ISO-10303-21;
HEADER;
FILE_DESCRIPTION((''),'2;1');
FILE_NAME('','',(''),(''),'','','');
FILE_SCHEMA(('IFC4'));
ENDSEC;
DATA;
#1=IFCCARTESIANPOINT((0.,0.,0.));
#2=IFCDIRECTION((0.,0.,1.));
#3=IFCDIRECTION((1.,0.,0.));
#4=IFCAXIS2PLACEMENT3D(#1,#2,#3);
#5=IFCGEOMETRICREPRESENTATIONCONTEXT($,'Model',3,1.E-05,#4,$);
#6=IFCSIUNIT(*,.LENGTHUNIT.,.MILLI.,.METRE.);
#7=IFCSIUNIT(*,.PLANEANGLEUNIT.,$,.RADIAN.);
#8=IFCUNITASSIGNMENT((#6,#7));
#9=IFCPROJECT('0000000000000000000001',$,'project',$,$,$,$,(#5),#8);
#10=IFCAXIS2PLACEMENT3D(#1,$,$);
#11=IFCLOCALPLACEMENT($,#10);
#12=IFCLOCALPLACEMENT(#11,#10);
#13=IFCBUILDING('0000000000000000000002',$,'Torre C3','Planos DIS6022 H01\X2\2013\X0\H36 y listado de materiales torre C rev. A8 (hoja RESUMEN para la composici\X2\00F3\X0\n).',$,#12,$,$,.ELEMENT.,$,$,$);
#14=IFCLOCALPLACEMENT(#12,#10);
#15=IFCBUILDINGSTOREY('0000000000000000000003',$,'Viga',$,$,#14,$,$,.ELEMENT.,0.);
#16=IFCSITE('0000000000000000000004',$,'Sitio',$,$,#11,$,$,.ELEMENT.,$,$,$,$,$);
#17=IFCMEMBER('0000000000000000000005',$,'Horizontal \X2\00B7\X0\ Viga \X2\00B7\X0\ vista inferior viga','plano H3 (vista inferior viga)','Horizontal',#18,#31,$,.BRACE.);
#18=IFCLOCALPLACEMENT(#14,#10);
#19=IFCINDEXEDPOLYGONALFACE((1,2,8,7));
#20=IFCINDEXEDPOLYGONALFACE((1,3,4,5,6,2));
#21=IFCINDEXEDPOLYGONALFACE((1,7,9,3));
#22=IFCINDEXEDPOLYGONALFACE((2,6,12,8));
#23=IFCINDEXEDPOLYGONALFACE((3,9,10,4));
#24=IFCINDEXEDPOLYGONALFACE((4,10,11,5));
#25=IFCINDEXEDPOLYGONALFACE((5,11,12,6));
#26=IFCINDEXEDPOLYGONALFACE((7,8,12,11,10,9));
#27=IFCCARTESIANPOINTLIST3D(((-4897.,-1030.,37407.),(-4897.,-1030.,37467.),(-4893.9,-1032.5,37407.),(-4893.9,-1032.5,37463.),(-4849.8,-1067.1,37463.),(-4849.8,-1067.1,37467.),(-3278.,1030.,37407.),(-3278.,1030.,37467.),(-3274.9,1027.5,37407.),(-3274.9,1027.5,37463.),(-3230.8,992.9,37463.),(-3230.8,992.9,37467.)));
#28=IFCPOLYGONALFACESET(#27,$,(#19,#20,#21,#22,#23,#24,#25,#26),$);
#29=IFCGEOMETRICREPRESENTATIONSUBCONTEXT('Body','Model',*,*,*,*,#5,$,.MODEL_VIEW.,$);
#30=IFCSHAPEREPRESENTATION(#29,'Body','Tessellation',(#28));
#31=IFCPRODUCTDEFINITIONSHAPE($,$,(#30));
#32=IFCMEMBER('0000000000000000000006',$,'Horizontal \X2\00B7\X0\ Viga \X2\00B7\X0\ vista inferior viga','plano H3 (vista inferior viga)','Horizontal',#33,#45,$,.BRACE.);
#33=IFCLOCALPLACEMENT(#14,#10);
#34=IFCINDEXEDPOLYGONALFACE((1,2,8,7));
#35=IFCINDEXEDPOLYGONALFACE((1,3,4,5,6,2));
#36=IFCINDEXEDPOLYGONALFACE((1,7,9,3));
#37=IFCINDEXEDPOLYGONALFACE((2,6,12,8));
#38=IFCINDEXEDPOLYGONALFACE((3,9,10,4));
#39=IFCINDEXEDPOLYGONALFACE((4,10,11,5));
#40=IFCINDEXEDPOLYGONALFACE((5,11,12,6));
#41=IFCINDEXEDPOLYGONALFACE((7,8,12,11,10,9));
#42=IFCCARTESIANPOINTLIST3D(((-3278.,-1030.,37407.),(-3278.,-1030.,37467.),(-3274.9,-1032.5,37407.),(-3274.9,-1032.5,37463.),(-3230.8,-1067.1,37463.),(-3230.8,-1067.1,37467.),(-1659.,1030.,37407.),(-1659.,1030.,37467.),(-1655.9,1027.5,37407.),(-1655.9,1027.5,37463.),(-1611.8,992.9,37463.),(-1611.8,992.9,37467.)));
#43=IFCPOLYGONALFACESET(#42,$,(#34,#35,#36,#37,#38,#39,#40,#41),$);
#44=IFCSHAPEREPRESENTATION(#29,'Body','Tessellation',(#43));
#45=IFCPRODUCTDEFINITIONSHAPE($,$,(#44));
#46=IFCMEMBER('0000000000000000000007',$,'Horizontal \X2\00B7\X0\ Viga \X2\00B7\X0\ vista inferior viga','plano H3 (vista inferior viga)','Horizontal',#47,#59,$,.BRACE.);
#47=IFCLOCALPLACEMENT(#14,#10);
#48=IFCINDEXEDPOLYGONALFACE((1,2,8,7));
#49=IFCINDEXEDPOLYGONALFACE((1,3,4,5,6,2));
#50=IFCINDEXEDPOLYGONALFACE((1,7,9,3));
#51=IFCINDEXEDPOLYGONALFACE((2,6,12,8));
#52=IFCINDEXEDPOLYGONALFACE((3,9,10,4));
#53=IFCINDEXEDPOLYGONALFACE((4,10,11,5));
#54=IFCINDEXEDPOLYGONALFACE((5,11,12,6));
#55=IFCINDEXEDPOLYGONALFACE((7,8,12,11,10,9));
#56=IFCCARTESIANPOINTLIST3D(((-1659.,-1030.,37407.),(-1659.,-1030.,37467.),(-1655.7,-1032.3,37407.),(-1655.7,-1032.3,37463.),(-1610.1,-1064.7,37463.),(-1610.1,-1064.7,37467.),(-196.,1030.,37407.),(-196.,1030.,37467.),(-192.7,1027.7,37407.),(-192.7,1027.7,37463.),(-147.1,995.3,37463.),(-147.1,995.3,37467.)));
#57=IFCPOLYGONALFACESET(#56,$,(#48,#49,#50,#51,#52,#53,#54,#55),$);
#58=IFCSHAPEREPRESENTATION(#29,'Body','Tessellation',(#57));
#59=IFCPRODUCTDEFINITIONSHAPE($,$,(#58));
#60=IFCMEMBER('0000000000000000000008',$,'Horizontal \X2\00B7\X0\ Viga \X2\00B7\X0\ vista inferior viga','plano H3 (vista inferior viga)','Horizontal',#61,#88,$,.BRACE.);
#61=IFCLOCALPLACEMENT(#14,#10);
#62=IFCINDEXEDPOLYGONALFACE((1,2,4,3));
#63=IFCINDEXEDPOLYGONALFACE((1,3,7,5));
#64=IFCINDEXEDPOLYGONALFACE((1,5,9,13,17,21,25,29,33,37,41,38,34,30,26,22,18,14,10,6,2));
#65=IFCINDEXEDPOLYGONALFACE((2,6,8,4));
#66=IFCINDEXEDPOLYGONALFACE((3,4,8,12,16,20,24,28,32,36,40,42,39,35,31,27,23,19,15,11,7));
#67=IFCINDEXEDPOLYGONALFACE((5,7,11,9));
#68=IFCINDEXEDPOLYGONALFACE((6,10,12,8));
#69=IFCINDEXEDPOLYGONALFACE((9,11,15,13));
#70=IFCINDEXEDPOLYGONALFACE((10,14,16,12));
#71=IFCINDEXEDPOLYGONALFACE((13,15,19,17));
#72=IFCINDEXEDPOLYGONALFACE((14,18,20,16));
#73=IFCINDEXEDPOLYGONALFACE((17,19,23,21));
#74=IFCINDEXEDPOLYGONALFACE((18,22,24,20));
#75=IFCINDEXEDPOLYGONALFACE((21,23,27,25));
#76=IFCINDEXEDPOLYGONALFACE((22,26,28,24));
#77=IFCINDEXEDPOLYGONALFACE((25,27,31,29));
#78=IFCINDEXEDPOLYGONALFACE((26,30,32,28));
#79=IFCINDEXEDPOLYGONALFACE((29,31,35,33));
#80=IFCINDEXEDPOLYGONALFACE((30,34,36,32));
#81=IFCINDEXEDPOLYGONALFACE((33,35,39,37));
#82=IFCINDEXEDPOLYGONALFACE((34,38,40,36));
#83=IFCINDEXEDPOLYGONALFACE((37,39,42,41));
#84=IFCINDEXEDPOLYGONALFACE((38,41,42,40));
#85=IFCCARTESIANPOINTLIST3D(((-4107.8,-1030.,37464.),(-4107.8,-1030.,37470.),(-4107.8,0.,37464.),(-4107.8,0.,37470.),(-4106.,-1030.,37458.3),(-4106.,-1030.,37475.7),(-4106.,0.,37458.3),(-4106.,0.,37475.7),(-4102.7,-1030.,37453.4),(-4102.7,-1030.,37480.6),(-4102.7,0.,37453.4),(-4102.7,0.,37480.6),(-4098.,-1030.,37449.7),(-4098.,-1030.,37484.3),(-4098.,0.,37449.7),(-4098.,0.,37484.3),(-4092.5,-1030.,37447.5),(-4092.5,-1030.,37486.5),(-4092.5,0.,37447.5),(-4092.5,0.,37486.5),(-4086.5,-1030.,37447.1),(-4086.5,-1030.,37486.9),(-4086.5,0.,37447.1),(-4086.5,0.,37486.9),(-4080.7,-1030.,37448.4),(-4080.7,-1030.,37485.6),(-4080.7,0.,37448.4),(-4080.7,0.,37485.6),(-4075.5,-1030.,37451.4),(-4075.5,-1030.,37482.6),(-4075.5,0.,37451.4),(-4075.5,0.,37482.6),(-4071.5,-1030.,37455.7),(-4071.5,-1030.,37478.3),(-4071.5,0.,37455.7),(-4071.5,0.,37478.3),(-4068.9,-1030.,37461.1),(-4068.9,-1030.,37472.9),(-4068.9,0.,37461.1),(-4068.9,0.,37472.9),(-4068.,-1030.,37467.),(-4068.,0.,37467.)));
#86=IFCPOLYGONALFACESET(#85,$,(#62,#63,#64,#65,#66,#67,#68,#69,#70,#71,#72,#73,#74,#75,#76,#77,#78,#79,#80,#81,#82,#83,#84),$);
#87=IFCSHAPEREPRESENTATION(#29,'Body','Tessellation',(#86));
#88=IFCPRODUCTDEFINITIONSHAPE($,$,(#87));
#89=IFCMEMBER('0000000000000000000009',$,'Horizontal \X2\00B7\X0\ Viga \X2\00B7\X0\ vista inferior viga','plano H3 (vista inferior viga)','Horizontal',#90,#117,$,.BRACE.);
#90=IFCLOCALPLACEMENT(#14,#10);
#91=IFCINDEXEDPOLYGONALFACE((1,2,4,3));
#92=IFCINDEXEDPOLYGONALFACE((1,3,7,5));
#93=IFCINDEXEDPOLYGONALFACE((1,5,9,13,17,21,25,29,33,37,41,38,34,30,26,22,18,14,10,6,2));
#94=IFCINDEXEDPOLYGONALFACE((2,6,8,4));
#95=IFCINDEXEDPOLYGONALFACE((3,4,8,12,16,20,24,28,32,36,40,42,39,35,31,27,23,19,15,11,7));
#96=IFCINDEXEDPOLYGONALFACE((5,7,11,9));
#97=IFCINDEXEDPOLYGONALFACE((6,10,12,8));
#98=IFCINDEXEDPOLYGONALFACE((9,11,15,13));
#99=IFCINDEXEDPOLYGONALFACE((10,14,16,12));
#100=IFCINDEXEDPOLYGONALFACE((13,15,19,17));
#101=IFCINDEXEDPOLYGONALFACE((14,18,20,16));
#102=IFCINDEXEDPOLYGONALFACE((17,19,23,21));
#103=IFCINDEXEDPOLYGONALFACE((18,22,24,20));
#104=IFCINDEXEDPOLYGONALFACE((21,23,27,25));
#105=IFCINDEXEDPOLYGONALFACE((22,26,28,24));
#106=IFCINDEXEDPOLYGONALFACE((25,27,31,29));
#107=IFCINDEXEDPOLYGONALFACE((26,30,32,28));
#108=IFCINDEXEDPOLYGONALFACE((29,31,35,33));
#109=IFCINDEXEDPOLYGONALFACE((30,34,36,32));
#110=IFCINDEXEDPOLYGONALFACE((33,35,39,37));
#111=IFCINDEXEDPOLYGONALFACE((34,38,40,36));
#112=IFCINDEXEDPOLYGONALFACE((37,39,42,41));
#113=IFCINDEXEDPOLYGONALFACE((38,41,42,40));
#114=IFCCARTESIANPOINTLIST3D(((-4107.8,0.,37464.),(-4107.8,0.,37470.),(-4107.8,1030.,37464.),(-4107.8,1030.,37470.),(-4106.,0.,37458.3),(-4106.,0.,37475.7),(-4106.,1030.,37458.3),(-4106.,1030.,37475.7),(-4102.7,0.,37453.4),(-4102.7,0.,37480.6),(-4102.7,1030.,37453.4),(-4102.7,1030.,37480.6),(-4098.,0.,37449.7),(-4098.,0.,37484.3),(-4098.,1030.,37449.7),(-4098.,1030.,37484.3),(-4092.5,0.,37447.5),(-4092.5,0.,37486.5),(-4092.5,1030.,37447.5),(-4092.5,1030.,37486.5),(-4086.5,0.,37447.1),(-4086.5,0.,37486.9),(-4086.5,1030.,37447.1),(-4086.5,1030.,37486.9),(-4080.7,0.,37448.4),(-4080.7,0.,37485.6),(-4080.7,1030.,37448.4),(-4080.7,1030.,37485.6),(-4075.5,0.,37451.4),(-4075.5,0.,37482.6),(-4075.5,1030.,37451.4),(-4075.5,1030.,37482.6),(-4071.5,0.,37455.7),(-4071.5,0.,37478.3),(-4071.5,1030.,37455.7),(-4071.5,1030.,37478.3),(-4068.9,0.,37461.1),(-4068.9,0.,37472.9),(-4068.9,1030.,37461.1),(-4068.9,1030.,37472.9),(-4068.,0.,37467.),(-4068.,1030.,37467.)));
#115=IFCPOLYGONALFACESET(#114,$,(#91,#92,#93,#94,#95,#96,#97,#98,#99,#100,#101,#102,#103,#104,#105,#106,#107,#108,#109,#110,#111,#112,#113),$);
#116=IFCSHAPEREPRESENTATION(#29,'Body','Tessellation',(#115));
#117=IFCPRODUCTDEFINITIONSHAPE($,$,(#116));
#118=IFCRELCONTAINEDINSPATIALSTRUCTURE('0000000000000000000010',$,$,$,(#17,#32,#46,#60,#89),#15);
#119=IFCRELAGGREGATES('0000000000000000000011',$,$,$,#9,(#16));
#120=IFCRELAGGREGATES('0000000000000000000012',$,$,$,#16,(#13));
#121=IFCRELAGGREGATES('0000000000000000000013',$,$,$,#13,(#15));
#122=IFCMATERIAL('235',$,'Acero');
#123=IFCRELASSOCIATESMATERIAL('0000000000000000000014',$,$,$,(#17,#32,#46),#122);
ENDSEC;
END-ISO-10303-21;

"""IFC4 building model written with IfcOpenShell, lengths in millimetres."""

from ifc_helpers import new_model, si_unit, frame, frame_2d, origin, origin_with_axes, place, context, subcontext, project, spatial, circle, l_section, extrude, material, element, save


model = new_model("IFC4")

# Units and contexts
model_context = context("Model", 3, precision=1e-05, world=origin_with_axes())
body_context = subcontext(model_context, "Body", "Model", "MODEL_VIEW")
ifc_project = project(units=[si_unit("LENGTHUNIT", "METRE", prefix="MILLI"), si_unit("PLANEANGLEUNIT", "RADIAN")], contexts=[model_context])

# Site, building, storey
site_placement = place(None, origin())
site = spatial("IfcSite", under=ifc_project, at=site_placement, Name="Sitio", CompositionType="ELEMENT")
building_placement = place(site_placement, origin())
building = spatial("IfcBuilding", under=site, at=building_placement, Name="Torre C3", Description="Planos DIS6022 H01–H36 y listado de materiales torre C rev. A8 (hoja RESUMEN para la composición).", CompositionType="ELEMENT")
storey_placement = place(building_placement, origin())
storey = spatial("IfcBuildingStorey", under=building, at=storey_placement, Name="Viga", CompositionType="ELEMENT", Elevation=0.0)

# Members
ifc_material_1 = material(Name="235", Category="Acero")
for number, where, z_axis, x_axis, name in (
    (1, (-4897.0, -1030.0, 37467.0), (0.617923, 0.786239, 0.0), (0.786239, -0.617923, 0.0), "Horizontal · Viga · vista inferior viga"),
    (2, (-3278.0, -1030.0, 37467.0), (0.617923, 0.786239, 0.0), (0.786239, -0.617923, 0.0), "Horizontal · Viga · vista inferior viga"),
):
    element("IfcMember", number, at=place(storey_placement, frame(where, z_axis=z_axis, x_axis=x_axis)), inside=storey, material=ifc_material_1, Name=name, Description="plano H3 (vista inferior viga)", ObjectType="Horizontal", PredefinedType="BRACE", context=body_context, shape_type="SweptSolid", body=[
        extrude(l_section(Depth=60.0, Width=60.0, Thickness=4.0, at=frame_2d((30.0, 30.0))), None, (0.0, 0.0, 1.0), 2620.1),
    ])
member_1_placement = place(storey_placement, frame((-1659.0, -1030.0, 37467.0), z_axis=(0.579027, 0.815308, 0.0), x_axis=(0.815308, -0.579027, 0.0)))
element("IfcMember", 3, at=member_1_placement, inside=storey, material=ifc_material_1, Name="Horizontal · Viga · vista inferior viga", Description="plano H3 (vista inferior viga)", ObjectType="Horizontal", PredefinedType="BRACE", context=body_context, shape_type="SweptSolid", body=[
    extrude(l_section(Depth=60.0, Width=60.0, Thickness=4.0, at=frame_2d((30.0, 30.0))), None, (0.0, 0.0, 1.0), 2526.7),
])
for number, where, z_axis, x_axis, name in (
    (4, (-4088.0, 0.0, 37467.0), (0.0, -1.0, 0.0), (1.0, 0.0, 0.0), "Horizontal · Viga · vista inferior viga"),
    (5, (-4088.0, 0.0, 37467.0), (0.0, 1.0, 0.0), (1.0, 0.0, 0.0), "Horizontal · Viga · vista inferior viga"),
):
    element("IfcMember", number, at=place(storey_placement, frame(where, z_axis=z_axis, x_axis=x_axis)), inside=storey, Name=name, Description="plano H3 (vista inferior viga)", ObjectType="Horizontal", PredefinedType="BRACE", context=body_context, shape_type="SweptSolid", body=[
        extrude(circle(Radius=20.0), None, (0.0, 0.0, 1.0), 1030.0),
    ])

save(model, "model.ifc")
